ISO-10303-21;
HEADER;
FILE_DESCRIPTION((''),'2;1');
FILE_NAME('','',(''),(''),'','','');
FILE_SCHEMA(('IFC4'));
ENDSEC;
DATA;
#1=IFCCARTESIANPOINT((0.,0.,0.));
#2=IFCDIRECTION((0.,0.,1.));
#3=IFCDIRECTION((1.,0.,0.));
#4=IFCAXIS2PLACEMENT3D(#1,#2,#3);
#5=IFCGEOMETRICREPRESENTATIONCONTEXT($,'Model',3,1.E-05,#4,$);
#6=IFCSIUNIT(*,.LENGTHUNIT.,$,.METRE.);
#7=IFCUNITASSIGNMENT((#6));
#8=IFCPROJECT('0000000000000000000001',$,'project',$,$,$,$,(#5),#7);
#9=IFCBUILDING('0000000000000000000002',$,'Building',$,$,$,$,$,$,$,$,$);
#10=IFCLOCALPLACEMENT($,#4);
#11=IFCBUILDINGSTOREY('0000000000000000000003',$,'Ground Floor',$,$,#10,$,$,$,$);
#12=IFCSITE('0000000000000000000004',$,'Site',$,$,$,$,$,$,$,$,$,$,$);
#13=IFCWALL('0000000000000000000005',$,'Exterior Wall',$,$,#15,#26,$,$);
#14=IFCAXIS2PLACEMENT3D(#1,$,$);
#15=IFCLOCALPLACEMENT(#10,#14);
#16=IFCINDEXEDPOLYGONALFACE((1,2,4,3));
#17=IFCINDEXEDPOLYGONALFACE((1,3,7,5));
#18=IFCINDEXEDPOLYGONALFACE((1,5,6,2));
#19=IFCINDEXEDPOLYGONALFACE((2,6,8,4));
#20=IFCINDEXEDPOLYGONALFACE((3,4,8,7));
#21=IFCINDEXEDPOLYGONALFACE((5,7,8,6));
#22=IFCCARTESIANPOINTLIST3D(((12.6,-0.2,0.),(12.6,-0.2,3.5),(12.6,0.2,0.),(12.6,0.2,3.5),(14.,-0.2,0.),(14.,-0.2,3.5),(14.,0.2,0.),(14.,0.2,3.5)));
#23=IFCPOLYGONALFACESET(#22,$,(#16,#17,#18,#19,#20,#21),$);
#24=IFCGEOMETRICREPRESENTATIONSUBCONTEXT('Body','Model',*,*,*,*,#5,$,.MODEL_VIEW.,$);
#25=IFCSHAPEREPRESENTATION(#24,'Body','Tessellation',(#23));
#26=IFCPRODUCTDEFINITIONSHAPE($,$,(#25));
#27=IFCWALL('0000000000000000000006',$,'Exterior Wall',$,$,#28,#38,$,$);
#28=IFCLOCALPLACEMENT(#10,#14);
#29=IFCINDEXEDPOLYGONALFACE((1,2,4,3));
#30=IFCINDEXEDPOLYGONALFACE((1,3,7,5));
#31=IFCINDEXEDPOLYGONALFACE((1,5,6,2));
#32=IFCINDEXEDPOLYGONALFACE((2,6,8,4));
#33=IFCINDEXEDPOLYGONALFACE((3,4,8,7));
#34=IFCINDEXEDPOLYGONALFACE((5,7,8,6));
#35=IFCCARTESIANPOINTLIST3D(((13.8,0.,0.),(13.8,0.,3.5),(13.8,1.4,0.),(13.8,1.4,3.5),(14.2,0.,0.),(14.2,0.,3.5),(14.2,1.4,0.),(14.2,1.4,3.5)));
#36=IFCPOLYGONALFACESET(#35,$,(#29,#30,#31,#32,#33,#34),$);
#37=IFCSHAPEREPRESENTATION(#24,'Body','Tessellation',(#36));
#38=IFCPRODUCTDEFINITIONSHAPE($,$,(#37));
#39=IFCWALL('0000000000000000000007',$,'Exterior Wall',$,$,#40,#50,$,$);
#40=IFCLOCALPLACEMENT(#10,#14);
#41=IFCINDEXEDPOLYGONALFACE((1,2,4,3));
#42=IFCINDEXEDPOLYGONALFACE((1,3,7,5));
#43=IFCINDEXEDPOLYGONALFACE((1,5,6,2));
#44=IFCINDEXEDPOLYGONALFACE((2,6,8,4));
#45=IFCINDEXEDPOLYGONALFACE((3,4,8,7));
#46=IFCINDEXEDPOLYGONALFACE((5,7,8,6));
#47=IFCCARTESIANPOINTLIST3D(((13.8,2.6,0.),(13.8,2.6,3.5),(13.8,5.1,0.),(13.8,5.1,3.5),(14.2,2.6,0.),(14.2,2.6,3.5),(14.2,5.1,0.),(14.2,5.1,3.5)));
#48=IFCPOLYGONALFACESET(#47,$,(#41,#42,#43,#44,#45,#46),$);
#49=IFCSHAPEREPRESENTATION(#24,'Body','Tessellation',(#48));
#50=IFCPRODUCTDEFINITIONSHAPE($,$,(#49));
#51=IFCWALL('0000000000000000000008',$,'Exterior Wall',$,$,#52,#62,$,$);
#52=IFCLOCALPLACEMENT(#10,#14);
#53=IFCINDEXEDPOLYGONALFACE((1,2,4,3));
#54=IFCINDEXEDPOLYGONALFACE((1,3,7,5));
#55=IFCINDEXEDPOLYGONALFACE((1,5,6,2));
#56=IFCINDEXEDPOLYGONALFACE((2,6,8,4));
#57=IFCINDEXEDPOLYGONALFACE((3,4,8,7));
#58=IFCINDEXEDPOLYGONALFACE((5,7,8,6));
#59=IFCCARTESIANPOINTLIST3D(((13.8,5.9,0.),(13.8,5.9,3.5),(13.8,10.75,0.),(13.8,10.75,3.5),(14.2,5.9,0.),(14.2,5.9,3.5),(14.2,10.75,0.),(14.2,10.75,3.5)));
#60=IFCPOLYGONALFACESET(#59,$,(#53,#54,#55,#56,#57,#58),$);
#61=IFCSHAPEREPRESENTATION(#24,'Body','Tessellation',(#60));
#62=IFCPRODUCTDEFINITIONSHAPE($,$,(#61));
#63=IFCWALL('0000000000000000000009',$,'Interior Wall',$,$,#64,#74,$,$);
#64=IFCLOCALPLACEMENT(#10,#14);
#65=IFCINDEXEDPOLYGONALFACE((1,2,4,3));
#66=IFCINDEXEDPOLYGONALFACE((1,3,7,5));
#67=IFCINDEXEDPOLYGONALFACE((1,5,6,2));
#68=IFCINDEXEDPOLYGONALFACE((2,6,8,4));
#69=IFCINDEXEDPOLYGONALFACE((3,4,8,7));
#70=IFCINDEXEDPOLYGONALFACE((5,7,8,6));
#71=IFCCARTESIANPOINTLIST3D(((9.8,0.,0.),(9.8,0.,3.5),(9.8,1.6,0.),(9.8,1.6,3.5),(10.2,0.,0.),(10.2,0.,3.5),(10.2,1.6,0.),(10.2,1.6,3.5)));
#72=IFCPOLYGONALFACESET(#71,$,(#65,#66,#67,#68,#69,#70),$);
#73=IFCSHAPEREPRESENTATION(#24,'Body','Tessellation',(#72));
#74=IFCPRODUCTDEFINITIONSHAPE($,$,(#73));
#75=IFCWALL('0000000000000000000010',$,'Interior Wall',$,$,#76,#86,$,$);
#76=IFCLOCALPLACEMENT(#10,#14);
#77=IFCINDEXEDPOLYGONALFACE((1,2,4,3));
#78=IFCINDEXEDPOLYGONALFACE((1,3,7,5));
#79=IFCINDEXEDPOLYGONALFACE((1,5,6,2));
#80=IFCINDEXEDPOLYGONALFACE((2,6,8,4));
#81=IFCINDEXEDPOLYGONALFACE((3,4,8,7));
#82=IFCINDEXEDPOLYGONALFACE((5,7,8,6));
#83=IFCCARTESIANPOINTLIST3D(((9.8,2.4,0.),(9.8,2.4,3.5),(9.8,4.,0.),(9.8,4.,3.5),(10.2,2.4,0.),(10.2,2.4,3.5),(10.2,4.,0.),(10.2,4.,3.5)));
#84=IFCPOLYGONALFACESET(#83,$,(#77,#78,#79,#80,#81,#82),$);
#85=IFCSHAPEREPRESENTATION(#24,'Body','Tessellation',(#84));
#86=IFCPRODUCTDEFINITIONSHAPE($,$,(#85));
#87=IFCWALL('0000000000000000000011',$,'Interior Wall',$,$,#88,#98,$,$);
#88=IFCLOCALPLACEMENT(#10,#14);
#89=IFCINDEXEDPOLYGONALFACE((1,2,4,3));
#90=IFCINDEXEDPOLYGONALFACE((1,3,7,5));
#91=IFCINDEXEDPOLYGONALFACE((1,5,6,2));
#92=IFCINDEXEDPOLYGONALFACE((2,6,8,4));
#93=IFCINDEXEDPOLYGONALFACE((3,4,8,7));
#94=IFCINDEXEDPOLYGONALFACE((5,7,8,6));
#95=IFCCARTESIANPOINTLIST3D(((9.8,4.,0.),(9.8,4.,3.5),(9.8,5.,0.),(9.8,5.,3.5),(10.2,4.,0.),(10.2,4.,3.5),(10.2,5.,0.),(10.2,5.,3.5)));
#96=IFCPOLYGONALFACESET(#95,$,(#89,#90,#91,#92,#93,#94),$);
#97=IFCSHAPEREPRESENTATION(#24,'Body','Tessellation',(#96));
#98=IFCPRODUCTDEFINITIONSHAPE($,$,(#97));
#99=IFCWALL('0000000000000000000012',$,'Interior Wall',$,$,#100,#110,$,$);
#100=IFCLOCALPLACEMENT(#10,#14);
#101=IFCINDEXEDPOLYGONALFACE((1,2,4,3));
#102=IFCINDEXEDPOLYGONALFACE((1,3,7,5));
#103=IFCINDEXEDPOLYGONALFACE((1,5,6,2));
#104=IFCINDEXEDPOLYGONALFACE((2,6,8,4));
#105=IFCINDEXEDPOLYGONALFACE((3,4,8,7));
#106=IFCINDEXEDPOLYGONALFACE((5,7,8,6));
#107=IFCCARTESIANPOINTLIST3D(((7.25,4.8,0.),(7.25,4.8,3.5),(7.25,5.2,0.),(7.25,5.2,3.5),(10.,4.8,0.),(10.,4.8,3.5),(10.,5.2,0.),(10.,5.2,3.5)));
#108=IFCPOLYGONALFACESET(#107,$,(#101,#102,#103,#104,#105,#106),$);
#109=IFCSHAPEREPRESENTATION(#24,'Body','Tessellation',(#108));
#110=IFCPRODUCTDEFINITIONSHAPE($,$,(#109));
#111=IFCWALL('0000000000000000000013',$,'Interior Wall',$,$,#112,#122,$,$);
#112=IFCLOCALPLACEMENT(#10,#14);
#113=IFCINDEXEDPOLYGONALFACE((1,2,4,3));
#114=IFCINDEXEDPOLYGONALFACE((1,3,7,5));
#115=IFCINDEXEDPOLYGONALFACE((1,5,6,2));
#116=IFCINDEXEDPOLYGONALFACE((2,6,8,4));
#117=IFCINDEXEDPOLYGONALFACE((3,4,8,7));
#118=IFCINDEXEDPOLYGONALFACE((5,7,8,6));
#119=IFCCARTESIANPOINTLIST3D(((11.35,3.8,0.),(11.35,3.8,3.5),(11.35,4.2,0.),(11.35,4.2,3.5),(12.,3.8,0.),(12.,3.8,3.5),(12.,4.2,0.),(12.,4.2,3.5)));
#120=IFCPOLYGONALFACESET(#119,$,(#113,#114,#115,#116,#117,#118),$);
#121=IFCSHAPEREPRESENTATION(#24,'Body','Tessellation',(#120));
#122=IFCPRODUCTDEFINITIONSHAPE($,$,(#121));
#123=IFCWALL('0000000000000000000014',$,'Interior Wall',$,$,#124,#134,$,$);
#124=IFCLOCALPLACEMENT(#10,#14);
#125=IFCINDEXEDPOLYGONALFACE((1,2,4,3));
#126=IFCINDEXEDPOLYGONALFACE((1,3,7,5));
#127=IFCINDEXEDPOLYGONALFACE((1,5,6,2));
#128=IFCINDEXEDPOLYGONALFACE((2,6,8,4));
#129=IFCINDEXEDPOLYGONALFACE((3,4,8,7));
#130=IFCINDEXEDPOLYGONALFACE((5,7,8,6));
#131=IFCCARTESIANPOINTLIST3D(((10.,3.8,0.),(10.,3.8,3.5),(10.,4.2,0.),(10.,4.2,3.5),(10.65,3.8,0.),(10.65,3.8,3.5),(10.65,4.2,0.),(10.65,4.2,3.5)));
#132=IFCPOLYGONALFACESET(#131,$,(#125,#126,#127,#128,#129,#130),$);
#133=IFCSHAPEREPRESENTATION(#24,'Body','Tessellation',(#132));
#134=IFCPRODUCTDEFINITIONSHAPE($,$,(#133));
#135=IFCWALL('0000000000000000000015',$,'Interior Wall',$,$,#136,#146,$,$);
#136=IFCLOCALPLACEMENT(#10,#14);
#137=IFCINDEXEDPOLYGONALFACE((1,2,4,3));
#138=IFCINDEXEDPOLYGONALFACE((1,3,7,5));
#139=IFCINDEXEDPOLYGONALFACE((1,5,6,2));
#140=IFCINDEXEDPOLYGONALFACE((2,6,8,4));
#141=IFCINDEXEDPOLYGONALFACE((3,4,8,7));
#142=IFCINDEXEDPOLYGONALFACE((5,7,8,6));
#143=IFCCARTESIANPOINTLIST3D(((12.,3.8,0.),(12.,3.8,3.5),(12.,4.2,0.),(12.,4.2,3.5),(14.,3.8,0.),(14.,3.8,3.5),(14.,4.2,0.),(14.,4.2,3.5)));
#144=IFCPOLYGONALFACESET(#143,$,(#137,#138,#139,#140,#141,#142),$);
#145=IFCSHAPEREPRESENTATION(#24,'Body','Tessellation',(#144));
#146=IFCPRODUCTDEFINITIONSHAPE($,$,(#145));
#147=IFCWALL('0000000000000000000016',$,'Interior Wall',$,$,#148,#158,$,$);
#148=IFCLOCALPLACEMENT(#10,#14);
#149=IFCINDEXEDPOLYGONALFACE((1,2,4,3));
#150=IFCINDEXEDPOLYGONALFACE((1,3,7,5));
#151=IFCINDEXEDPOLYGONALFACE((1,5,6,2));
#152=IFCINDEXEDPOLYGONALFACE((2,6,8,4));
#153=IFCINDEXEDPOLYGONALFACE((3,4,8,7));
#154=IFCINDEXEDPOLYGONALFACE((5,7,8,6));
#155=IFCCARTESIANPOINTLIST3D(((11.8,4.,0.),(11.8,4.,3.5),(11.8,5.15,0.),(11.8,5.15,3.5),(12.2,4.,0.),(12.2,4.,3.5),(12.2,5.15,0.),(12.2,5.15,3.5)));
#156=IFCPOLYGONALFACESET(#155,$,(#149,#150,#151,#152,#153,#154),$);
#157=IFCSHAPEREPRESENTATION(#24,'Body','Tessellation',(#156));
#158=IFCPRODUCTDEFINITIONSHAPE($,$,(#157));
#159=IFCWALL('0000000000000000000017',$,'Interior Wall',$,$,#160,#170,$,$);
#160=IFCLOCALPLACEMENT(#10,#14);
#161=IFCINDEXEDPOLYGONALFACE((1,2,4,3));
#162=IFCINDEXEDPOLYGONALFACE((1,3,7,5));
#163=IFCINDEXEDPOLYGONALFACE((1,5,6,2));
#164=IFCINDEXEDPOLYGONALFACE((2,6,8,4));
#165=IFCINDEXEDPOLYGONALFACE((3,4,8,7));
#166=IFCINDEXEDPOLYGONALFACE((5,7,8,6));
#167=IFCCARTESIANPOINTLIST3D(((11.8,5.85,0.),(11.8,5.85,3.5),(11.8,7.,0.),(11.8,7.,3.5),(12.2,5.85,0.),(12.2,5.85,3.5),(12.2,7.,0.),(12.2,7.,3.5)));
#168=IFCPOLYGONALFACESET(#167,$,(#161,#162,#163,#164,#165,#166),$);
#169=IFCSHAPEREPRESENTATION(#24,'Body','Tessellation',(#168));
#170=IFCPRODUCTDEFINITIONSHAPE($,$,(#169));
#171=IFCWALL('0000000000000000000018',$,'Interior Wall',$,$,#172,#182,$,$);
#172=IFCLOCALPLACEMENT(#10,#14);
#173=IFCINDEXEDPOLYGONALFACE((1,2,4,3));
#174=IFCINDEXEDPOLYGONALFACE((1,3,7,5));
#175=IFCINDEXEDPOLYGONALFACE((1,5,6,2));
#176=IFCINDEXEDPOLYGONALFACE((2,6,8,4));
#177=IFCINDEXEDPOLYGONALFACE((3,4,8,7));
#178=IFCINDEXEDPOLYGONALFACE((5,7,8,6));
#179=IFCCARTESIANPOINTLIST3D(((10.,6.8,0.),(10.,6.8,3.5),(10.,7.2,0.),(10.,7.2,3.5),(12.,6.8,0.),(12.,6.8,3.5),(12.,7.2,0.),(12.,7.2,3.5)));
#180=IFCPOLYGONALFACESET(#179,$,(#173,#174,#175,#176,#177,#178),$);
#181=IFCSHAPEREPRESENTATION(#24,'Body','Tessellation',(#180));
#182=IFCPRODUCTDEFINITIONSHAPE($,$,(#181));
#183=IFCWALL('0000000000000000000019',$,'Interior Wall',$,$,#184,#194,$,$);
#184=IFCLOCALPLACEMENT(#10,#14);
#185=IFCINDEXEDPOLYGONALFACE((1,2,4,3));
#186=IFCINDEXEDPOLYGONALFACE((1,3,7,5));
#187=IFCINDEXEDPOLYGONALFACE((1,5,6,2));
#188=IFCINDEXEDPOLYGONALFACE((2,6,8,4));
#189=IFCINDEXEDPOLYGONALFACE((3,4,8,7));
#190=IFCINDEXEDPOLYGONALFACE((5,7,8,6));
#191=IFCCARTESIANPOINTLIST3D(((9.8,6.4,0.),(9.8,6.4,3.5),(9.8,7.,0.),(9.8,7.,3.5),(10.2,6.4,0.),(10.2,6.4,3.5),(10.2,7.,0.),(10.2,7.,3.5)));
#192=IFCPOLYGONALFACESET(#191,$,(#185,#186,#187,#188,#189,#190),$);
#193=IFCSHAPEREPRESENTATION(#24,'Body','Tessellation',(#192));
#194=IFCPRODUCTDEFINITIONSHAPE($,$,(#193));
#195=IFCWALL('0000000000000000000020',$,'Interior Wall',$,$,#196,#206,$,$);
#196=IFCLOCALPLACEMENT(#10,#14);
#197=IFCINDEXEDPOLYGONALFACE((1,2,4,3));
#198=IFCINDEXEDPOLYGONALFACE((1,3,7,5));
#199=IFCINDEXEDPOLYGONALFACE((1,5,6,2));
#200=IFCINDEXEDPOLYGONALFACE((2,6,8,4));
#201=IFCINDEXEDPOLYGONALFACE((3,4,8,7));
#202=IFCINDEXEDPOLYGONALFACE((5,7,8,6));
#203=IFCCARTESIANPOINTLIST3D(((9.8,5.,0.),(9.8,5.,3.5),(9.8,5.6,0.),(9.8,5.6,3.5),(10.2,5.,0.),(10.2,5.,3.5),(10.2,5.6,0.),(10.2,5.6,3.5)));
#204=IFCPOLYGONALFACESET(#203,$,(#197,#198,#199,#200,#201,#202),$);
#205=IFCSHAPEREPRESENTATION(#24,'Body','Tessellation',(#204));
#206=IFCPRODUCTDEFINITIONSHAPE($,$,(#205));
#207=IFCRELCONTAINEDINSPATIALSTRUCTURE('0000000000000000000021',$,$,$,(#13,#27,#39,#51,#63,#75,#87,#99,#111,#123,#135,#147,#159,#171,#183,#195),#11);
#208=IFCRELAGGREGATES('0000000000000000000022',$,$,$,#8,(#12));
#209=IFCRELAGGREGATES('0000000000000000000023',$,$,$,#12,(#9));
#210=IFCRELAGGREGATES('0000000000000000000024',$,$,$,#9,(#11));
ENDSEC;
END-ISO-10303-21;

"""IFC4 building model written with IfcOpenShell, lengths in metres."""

from ifc_helpers import new_model, si_unit, frame, origin_with_axes, place, context, subcontext, project, spatial, indexed_curve, outline, extrude, element, save


model = new_model("IFC4")

# Units and contexts
model_context = context("Model", 3, precision=1e-05, world=origin_with_axes())
body_context = subcontext(model_context, "Body", "Model", "MODEL_VIEW")
ifc_project = project(units=[si_unit("LENGTHUNIT", "METRE")], contexts=[model_context])

# Site, building, storey
site = spatial("IfcSite", under=ifc_project, Name="Site")
building = spatial("IfcBuilding", under=site, Name="Building")
storey_placement = place(None, origin_with_axes())
storey = spatial("IfcBuildingStorey", under=building, at=storey_placement, Name="Ground Floor")

# Walls
wall_1_placement = place(storey_placement, frame((12.6, 0.0, 0.0), z_axis=(0.0, 0.0, 1.0), x_axis=(1.0, 0.0, 0.0)))
element("IfcWall", 1, at=wall_1_placement, inside=storey, Name="Exterior Wall", context=body_context, shape_type="SweptSolid", body=[
    extrude(outline(indexed_curve([(0.0, 0.0), (0.0, 0.4), (1.4, 0.4), (1.4, 0.0), (0.0, 0.0)], self_intersect=False)), frame((0.0, -0.2, 0.0), z_axis=(0.0, 0.0, 1.0), x_axis=(1.0, 0.0, 0.0)), (0.0, 0.0, 1.0), 3.5),
])
wall_2_placement = place(storey_placement, frame((14.0, 0.0, 0.0), z_axis=(0.0, 0.0, 1.0), x_axis=(0.0, 1.0, 0.0)))
element("IfcWall", 2, at=wall_2_placement, inside=storey, Name="Exterior Wall", context=body_context, shape_type="SweptSolid", body=[
    extrude(outline(indexed_curve([(0.0, 0.0), (0.0, 0.4), (1.4, 0.4), (1.4, 0.0), (0.0, 0.0)], self_intersect=False)), frame((0.0, -0.2, 0.0), z_axis=(0.0, 0.0, 1.0), x_axis=(1.0, 0.0, 0.0)), (0.0, 0.0, 1.0), 3.5),
])
wall_3_placement = place(storey_placement, frame((14.0, 2.6, 0.0), z_axis=(0.0, 0.0, 1.0), x_axis=(0.0, 1.0, 0.0)))
element("IfcWall", 3, at=wall_3_placement, inside=storey, Name="Exterior Wall", context=body_context, shape_type="SweptSolid", body=[
    extrude(outline(indexed_curve([(0.0, 0.0), (0.0, 0.4), (2.5, 0.4), (2.5, 0.0), (0.0, 0.0)], self_intersect=False)), frame((0.0, -0.2, 0.0), z_axis=(0.0, 0.0, 1.0), x_axis=(1.0, 0.0, 0.0)), (0.0, 0.0, 1.0), 3.5),
])
wall_4_placement = place(storey_placement, frame((14.0, 5.9, 0.0), z_axis=(0.0, 0.0, 1.0), x_axis=(0.0, 1.0, 0.0)))
element("IfcWall", 4, at=wall_4_placement, inside=storey, Name="Exterior Wall", context=body_context, shape_type="SweptSolid", body=[
    extrude(outline(indexed_curve([(0.0, 0.0), (0.0, 0.4), (4.85, 0.4), (4.85, 0.0), (0.0, 0.0)], self_intersect=False)), frame((0.0, -0.2, 0.0), z_axis=(0.0, 0.0, 1.0), x_axis=(1.0, 0.0, 0.0)), (0.0, 0.0, 1.0), 3.5),
])
for number, where, z_axis, x_axis, name in (
    (5, (10.0, 0.0, 0.0), (0.0, 0.0, 1.0), (0.0, 1.0, 0.0), "Interior Wall"),
    (6, (10.0, 2.4, 0.0), (0.0, 0.0, 1.0), (0.0, 1.0, 0.0), "Interior Wall"),
):
    element("IfcWall", number, at=place(storey_placement, frame(where, z_axis=z_axis, x_axis=x_axis)), inside=storey, Name=name, context=body_context, shape_type="SweptSolid", body=[
        extrude(outline(indexed_curve([(0.0, 0.0), (0.0, 0.4), (1.6, 0.4), (1.6, 0.0), (0.0, 0.0)], self_intersect=False)), frame((0.0, -0.2, 0.0), z_axis=(0.0, 0.0, 1.0), x_axis=(1.0, 0.0, 0.0)), (0.0, 0.0, 1.0), 3.5),
    ])
wall_5_placement = place(storey_placement, frame((10.0, 4.0, 0.0), z_axis=(0.0, 0.0, 1.0), x_axis=(0.0, 1.0, 0.0)))
element("IfcWall", 7, at=wall_5_placement, inside=storey, Name="Interior Wall", context=body_context, shape_type="SweptSolid", body=[
    extrude(outline(indexed_curve([(0.0, 0.0), (0.0, 0.4), (1.0, 0.4), (1.0, 0.0), (0.0, 0.0)], self_intersect=False)), frame((0.0, -0.2, 0.0), z_axis=(0.0, 0.0, 1.0), x_axis=(1.0, 0.0, 0.0)), (0.0, 0.0, 1.0), 3.5),
])
wall_6_placement = place(storey_placement, frame((10.0, 5.0, 0.0), z_axis=(0.0, 0.0, 1.0), x_axis=(-1.0, 0.0, 0.0)))
element("IfcWall", 8, at=wall_6_placement, inside=storey, Name="Interior Wall", context=body_context, shape_type="SweptSolid", body=[
    extrude(outline(indexed_curve([(0.0, 0.0), (0.0, 0.4), (2.75, 0.4), (2.75, 0.0), (0.0, 0.0)], self_intersect=False)), frame((0.0, -0.2, 0.0), z_axis=(0.0, 0.0, 1.0), x_axis=(1.0, 0.0, 0.0)), (0.0, 0.0, 1.0), 3.5),
])
for number, where, z_axis, x_axis, name in (
    (9, (12.0, 4.0, 0.0), (0.0, 0.0, 1.0), (-1.0, 0.0, 0.0), "Interior Wall"),
    (10, (10.65, 4.0, 0.0), (0.0, 0.0, 1.0), (-1.0, 0.0, 0.0), "Interior Wall"),
):
    element("IfcWall", number, at=place(storey_placement, frame(where, z_axis=z_axis, x_axis=x_axis)), inside=storey, Name=name, context=body_context, shape_type="SweptSolid", body=[
        extrude(outline(indexed_curve([(0.0, 0.0), (0.0, 0.4), (0.65, 0.4), (0.65, 0.0), (0.0, 0.0)], self_intersect=False)), frame((0.0, -0.2, 0.0), z_axis=(0.0, 0.0, 1.0), x_axis=(1.0, 0.0, 0.0)), (0.0, 0.0, 1.0), 3.5),
    ])
wall_7_placement = place(storey_placement, frame((14.0, 4.0, 0.0), z_axis=(0.0, 0.0, 1.0), x_axis=(-1.0, 0.0, 0.0)))
element("IfcWall", 11, at=wall_7_placement, inside=storey, Name="Interior Wall", context=body_context, shape_type="SweptSolid", body=[
    extrude(outline(indexed_curve([(0.0, 0.0), (0.0, 0.4), (2.0, 0.4), (2.0, 0.0), (0.0, 0.0)], self_intersect=False)), frame((0.0, -0.2, 0.0), z_axis=(0.0, 0.0, 1.0), x_axis=(1.0, 0.0, 0.0)), (0.0, 0.0, 1.0), 3.5),
])
for number, where, z_axis, x_axis, name in (
    (12, (12.0, 4.0, 0.0), (0.0, 0.0, 1.0), (0.0, 1.0, 0.0), "Interior Wall"),
    (13, (12.0, 5.85, 0.0), (0.0, 0.0, 1.0), (0.0, 1.0, 0.0), "Interior Wall"),
):
    element("IfcWall", number, at=place(storey_placement, frame(where, z_axis=z_axis, x_axis=x_axis)), inside=storey, Name=name, context=body_context, shape_type="SweptSolid", body=[
        extrude(outline(indexed_curve([(0.0, 0.0), (0.0, 0.4), (1.15, 0.4), (1.15, 0.0), (0.0, 0.0)], self_intersect=False)), frame((0.0, -0.2, 0.0), z_axis=(0.0, 0.0, 1.0), x_axis=(1.0, 0.0, 0.0)), (0.0, 0.0, 1.0), 3.5),
    ])
wall_8_placement = place(storey_placement, frame((12.0, 7.0, 0.0), z_axis=(0.0, 0.0, 1.0), x_axis=(-1.0, 0.0, 0.0)))
element("IfcWall", 14, at=wall_8_placement, inside=storey, Name="Interior Wall", context=body_context, shape_type="SweptSolid", body=[
    extrude(outline(indexed_curve([(0.0, 0.0), (0.0, 0.4), (2.0, 0.4), (2.0, 0.0), (0.0, 0.0)], self_intersect=False)), frame((0.0, -0.2, 0.0), z_axis=(0.0, 0.0, 1.0), x_axis=(1.0, 0.0, 0.0)), (0.0, 0.0, 1.0), 3.5),
])
for number, where, z_axis, x_axis, name in (
    (15, (10.0, 7.0, 0.0), (0.0, 0.0, 1.0), (0.0, -1.0, 0.0), "Interior Wall"),
    (16, (10.0, 5.6, 0.0), (0.0, 0.0, 1.0), (0.0, -1.0, 0.0), "Interior Wall"),
):
    element("IfcWall", number, at=place(storey_placement, frame(where, z_axis=z_axis, x_axis=x_axis)), inside=storey, Name=name, context=body_context, shape_type="SweptSolid", body=[
        extrude(outline(indexed_curve([(0.0, 0.0), (0.0, 0.4), (0.6, 0.4), (0.6, 0.0), (0.0, 0.0)], self_intersect=False)), frame((0.0, -0.2, 0.0), z_axis=(0.0, 0.0, 1.0), x_axis=(1.0, 0.0, 0.0)), (0.0, 0.0, 1.0), 3.5),
    ])

save(model, "model.ifc")
